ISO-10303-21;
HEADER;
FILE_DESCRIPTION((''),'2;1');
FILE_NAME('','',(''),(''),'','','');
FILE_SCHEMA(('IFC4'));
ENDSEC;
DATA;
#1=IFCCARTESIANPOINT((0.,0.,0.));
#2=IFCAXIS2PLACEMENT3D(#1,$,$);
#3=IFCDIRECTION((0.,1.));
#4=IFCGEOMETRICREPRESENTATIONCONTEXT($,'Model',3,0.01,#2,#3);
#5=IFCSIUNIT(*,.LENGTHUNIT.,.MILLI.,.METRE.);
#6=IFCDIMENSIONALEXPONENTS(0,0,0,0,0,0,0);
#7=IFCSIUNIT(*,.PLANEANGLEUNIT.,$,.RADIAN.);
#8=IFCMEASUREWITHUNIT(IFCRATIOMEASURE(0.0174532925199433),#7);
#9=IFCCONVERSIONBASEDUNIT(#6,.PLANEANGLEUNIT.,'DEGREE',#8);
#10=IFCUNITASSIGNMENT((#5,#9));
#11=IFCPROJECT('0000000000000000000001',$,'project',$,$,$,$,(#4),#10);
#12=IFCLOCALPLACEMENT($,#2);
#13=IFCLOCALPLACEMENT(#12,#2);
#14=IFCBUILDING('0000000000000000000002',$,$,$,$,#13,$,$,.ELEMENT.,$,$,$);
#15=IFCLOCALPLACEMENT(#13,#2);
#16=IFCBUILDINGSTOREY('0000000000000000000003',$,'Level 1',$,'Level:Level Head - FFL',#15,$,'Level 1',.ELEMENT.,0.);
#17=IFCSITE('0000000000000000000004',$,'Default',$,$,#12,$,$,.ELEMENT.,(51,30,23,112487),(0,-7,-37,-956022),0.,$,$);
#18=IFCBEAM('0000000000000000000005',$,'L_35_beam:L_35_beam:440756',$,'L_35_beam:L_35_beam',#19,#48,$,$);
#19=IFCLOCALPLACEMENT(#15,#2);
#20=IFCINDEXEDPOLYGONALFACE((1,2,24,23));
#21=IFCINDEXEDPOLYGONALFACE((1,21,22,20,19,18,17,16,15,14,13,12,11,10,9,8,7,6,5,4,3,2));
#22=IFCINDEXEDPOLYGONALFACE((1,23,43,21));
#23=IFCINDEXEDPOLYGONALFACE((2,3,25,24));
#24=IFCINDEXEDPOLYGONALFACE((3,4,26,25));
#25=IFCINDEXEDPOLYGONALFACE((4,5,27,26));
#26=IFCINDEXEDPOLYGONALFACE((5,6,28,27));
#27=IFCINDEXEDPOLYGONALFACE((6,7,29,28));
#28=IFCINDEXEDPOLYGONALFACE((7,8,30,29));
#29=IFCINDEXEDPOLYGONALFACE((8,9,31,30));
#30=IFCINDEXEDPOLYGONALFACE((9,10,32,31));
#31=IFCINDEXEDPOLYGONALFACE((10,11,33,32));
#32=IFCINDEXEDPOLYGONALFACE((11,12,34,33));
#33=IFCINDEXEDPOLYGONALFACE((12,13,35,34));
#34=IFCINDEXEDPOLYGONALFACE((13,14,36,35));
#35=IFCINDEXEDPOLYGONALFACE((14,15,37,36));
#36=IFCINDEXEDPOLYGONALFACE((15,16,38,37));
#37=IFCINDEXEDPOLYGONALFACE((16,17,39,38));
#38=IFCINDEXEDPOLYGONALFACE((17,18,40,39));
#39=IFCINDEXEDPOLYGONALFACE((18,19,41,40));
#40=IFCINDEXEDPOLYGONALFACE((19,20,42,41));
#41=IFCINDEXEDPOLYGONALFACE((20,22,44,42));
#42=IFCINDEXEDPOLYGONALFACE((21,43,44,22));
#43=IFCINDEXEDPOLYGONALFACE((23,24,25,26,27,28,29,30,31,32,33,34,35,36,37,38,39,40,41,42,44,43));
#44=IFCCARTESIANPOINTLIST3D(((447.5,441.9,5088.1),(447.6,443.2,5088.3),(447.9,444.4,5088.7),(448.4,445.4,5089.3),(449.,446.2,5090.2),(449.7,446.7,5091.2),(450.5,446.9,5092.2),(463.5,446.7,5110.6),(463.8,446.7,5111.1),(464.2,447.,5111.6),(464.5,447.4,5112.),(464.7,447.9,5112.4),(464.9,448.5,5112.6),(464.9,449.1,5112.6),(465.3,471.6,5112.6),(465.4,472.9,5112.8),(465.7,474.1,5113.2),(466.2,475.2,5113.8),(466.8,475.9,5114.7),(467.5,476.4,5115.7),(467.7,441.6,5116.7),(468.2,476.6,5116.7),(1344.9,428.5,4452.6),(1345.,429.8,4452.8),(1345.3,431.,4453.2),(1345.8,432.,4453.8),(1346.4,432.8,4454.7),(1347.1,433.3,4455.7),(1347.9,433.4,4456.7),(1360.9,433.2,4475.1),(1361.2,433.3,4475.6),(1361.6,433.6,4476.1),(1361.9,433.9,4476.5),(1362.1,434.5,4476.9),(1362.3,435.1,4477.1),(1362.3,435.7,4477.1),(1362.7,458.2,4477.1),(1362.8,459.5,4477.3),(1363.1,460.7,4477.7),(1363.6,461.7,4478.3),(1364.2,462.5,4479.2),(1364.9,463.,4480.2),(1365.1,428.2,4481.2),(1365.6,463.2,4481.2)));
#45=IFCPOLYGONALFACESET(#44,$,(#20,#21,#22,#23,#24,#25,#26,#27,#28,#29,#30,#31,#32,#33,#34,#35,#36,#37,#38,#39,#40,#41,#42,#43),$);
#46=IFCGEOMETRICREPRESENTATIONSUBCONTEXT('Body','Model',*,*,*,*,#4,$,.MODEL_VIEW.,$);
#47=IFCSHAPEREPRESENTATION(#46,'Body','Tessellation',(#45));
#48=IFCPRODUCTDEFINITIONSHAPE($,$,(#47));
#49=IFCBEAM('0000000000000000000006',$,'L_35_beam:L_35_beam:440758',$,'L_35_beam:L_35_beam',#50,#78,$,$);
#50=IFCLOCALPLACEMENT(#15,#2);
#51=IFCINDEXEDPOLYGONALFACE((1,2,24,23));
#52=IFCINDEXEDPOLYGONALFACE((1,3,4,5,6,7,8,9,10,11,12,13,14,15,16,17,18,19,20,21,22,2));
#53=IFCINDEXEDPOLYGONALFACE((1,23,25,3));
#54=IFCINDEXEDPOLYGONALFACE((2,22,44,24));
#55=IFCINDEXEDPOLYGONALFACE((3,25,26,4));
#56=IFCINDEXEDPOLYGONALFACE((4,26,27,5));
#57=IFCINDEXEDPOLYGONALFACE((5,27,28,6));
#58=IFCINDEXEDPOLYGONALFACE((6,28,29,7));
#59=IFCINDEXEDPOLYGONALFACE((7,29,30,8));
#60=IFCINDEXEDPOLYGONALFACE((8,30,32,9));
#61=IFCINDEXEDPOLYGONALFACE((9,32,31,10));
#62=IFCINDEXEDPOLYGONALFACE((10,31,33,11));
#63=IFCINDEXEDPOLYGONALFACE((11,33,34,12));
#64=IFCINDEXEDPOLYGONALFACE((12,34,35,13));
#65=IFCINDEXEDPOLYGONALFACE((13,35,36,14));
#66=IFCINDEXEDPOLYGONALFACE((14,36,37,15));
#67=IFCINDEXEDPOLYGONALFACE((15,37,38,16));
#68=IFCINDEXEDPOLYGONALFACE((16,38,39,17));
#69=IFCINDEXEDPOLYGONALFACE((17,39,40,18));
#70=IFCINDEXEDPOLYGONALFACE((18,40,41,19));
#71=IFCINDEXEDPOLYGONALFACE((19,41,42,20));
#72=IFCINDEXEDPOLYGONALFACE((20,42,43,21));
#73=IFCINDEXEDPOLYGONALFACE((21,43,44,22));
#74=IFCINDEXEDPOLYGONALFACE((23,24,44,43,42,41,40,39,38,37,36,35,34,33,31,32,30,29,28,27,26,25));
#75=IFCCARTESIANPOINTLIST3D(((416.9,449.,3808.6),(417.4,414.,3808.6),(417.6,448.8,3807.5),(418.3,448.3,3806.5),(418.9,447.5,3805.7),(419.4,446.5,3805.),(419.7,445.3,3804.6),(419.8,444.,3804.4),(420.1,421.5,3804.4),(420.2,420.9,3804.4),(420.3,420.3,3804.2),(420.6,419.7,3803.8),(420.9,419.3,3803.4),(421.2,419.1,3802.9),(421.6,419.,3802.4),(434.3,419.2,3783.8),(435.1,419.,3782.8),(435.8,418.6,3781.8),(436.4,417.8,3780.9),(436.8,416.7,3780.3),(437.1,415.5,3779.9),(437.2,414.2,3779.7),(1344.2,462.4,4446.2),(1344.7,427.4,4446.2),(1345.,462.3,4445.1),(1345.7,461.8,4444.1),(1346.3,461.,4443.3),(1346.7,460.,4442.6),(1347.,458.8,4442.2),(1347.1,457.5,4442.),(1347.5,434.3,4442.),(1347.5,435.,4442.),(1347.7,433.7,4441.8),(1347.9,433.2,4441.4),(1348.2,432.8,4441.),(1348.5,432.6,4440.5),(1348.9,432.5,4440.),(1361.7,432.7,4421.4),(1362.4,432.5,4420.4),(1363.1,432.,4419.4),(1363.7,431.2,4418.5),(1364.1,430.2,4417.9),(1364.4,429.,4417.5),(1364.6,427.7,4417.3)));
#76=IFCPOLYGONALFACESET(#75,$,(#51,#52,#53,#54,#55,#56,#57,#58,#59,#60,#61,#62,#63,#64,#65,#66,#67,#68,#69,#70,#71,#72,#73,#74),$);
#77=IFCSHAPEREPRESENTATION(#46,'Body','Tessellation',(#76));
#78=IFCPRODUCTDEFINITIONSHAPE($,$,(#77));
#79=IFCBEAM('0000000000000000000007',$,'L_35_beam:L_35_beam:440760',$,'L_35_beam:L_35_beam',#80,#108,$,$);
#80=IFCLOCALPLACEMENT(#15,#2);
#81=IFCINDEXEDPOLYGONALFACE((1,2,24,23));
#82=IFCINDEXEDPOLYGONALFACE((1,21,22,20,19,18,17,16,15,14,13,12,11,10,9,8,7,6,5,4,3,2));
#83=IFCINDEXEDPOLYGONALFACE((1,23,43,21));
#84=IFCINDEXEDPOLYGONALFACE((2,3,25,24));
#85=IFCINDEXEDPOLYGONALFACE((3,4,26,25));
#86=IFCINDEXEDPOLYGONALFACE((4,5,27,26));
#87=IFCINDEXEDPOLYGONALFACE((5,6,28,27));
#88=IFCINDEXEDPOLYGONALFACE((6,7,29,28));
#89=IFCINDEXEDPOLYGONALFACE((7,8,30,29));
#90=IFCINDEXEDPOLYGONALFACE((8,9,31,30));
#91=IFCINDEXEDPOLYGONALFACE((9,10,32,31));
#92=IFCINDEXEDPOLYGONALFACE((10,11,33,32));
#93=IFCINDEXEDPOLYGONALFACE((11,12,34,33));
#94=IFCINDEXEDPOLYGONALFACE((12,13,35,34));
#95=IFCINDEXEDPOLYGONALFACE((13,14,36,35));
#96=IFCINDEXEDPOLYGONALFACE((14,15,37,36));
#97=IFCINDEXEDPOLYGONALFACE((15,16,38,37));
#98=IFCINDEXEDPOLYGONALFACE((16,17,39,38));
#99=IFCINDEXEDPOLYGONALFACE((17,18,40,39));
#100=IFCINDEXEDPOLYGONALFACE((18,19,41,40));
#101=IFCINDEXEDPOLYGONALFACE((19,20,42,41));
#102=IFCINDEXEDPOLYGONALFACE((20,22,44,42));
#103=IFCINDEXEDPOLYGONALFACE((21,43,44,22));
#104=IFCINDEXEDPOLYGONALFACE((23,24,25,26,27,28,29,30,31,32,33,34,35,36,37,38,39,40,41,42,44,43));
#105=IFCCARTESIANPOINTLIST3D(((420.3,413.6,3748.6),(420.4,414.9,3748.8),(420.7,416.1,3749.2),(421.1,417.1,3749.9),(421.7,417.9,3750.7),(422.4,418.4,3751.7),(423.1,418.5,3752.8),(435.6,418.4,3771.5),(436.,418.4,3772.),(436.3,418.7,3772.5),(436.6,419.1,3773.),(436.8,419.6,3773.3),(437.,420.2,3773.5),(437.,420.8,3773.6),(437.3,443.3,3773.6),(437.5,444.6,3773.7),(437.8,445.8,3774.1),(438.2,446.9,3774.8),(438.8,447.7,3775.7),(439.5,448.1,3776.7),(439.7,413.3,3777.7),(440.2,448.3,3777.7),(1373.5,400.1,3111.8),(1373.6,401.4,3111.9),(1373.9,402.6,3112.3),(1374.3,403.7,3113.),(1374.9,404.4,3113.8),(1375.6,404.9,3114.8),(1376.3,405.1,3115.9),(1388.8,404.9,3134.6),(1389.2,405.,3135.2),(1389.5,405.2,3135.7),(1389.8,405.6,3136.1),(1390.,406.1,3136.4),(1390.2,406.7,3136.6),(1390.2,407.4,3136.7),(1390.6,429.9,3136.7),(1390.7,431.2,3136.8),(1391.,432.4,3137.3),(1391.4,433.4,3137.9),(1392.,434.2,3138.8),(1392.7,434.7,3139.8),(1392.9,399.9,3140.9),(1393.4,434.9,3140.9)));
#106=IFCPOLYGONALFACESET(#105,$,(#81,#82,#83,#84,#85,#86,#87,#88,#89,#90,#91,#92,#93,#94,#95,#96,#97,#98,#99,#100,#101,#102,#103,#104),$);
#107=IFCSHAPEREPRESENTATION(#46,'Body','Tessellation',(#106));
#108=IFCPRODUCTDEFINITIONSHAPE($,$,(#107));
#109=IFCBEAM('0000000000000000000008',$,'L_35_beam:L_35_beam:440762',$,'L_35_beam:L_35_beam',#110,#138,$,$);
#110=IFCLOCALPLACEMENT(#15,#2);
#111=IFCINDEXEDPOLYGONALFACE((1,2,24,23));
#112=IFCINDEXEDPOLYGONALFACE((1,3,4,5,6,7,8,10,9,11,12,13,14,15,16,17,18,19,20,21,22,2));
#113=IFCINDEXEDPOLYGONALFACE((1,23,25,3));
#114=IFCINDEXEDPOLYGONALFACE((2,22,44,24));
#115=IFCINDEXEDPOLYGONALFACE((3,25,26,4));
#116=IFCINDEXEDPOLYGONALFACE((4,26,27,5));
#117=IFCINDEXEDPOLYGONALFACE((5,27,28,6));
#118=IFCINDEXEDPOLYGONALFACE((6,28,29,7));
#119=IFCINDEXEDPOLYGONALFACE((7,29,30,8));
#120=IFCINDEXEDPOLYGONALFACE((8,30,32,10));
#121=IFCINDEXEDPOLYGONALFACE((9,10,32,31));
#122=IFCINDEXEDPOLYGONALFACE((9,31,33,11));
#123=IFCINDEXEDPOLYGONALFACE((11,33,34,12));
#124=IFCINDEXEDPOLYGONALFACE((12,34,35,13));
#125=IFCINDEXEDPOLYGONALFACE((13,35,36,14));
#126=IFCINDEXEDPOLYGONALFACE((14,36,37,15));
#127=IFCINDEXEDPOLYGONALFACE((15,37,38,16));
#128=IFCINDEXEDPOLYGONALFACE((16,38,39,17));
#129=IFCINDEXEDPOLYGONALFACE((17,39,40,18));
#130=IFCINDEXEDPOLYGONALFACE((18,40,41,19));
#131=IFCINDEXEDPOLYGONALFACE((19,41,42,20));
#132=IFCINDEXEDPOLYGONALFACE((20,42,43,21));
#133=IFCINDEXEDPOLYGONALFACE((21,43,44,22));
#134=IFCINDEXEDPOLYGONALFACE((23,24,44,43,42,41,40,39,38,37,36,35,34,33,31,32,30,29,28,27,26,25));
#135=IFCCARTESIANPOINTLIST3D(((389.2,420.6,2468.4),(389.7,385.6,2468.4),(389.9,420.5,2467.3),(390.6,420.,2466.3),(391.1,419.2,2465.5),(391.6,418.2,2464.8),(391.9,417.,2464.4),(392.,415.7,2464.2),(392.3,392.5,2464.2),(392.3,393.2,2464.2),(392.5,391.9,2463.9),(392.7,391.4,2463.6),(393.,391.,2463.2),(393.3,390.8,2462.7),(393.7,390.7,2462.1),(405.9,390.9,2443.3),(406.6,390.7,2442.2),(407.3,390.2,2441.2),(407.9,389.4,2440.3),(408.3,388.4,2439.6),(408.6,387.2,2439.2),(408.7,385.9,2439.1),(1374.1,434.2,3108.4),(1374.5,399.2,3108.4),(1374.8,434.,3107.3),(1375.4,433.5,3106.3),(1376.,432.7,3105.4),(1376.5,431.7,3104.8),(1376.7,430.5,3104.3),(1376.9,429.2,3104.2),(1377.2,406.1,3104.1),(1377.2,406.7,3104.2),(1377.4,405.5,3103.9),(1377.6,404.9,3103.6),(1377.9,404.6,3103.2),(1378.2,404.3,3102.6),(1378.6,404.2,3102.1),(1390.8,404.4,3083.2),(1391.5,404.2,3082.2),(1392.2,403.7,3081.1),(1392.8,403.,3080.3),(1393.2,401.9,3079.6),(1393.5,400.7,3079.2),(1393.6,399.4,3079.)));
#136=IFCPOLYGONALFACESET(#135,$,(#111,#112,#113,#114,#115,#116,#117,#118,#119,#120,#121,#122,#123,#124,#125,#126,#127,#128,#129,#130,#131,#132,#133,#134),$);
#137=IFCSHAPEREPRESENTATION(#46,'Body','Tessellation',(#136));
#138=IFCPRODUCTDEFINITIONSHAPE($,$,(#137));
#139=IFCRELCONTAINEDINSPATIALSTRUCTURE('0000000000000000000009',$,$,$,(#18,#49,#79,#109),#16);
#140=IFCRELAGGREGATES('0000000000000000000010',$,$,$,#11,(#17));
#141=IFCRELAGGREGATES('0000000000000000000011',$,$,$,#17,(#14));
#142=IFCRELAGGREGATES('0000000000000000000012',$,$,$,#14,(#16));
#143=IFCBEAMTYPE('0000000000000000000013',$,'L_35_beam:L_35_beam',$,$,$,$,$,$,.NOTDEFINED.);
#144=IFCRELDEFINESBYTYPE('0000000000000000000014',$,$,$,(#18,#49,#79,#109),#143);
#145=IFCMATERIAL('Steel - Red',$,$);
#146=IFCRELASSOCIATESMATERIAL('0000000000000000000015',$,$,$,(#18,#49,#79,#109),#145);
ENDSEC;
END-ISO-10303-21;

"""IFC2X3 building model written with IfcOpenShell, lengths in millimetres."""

from ifc_helpers import new_model, entity, si_unit, converted_unit, direction, frame, frame_2d, origin, place, context, subcontext, project, spatial, polyline, circle_curve, parameter, trimmed, segment, composite_curve, outline, extrude, material, type_object, element, save


model = new_model("IFC2X3")

# Units and contexts
model_context = context("Model", 3, precision=0.01, world=origin(), true_north=direction((0.0, 1.0)))
body_context = subcontext(model_context, "Body", "Model", "MODEL_VIEW")
ifc_project = project(units=[si_unit("LENGTHUNIT", "METRE", prefix="MILLI"), converted_unit("PLANEANGLEUNIT", "DEGREE", entity("IfcRatioMeasure", 0.0174532925199433), si_unit("PLANEANGLEUNIT", "RADIAN"), dimensions=[0, 0, 0, 0, 0, 0, 0])], contexts=[model_context])

# Site, building, storey
site_placement = place(None, origin())
site = spatial("IfcSite", under=ifc_project, at=site_placement, Name="Default", CompositionType="ELEMENT", RefLatitude=(51, 30, 23, 112487), RefLongitude=(0, -7, -37, -956022), RefElevation=0.0)
building_placement = place(site_placement, origin())
building = spatial("IfcBuilding", under=site, at=building_placement, CompositionType="ELEMENT")
storey_placement = place(building_placement, origin())
storey = spatial("IfcBuildingStorey", under=building, at=storey_placement, Name="Level 1", ObjectType="Level:Level Head - FFL", LongName="Level 1", CompositionType="ELEMENT", Elevation=0.0)

# Beams
ifc_material_1 = material(Name="Steel - Red")
beam_type = type_object("IfcBeamType", Name="L_35_beam:L_35_beam", PredefinedType="NOTDEFINED")
beam_1_placement = place(storey_placement, frame((1380.0, 419.9, 4449.1), z_axis=(0.577808, -0.008646, 0.816127), x_axis=(-0.816035, 0.01221, 0.577873)))
element("IfcBeam", 1, at=beam_1_placement, inside=storey, type_object=beam_type, material=ifc_material_1, Name="L_35_beam:L_35_beam:440756", ObjectType="L_35_beam:L_35_beam", context=body_context, shape_type="SweptSolid", body=[
    extrude(outline(composite_curve([segment(polyline([(-23.2, -11.8), (11.8, -11.8)]), True, "CONTINUOUS"), segment(polyline([(11.8, -11.8), (11.8, 23.2)]), True, "CONTINUOUS"), segment(trimmed(circle_curve(frame_2d((11.8, 18.2), x_axis=(0.0, 1.0)), 5.0), [parameter(0.0)], [parameter(90.0)], True, "PARAMETER"), True, "CONTINUOUS"), segment(polyline([(6.8, 18.2), (6.8, -4.3)]), True, "CONTINUOUS"), segment(trimmed(circle_curve(frame_2d((4.3, -4.3), x_axis=(1.0, 0.0)), 2.5), [parameter(270.0)], [parameter(0.0)], True, "PARAMETER"), False, "CONTINUOUS"), segment(polyline([(4.3, -6.8), (-18.2, -6.8)]), True, "CONTINUOUS"), segment(trimmed(circle_curve(frame_2d((-18.2, -11.8), x_axis=(0.0, 1.0)), 5.0), [parameter(0.0)], [parameter(90.0)], True, "PARAMETER"), True, "CONTINUOUS")], self_intersect=False)), frame((30.8, -19.8, 5.7), z_axis=(1.0, 0.0, 0.0), x_axis=(0.0, 0.0, 1.0)), (0.0, 0.0, 1.0), 1099.7),
])
beam_2_placement = place(storey_placement, frame((1380.0, 419.9, 4449.1), z_axis=(-0.566466, -0.00823, 0.824044), x_axis=(-0.823957, -0.01197, -0.566525)))
element("IfcBeam", 2, at=beam_2_placement, inside=storey, type_object=beam_type, material=ifc_material_1, Name="L_35_beam:L_35_beam:440758", ObjectType="L_35_beam:L_35_beam", context=body_context, shape_type="SweptSolid", body=[
    extrude(outline(composite_curve([segment(polyline([(-23.2, -11.8), (11.8, -11.8)]), True, "CONTINUOUS"), segment(polyline([(11.8, -11.8), (11.8, 23.2)]), True, "CONTINUOUS"), segment(trimmed(circle_curve(frame_2d((11.8, 18.2), x_axis=(0.0, 1.0)), 5.0), [parameter(0.0)], [parameter(90.0)], True, "PARAMETER"), True, "CONTINUOUS"), segment(polyline([(6.8, 18.2), (6.8, -4.3)]), True, "CONTINUOUS"), segment(trimmed(circle_curve(frame_2d((4.3, -4.3), x_axis=(1.0, 0.0)), 2.5), [parameter(270.0)], [parameter(0.0)], True, "PARAMETER"), False, "CONTINUOUS"), segment(polyline([(4.3, -6.8), (-18.2, -6.8)]), True, "CONTINUOUS"), segment(trimmed(circle_curve(frame_2d((-18.2, -11.8), x_axis=(0.0, 1.0)), 5.0), [parameter(0.0)], [parameter(90.0)], True, "PARAMETER"), True, "CONTINUOUS")], self_intersect=False)), frame((30.7, -19.8, 5.7), z_axis=(1.0, 0.0, 0.0), x_axis=(0.0, 0.0, 1.0)), (0.0, 0.0, 1.0), 1125.5),
])
beam_3_placement = place(storey_placement, frame((1408.4, 391.6, 3109.4), z_axis=(0.555459, -0.007842, 0.831507), x_axis=(-0.831424, 0.011738, 0.555515)))
element("IfcBeam", 3, at=beam_3_placement, inside=storey, type_object=beam_type, material=ifc_material_1, Name="L_35_beam:L_35_beam:440760", ObjectType="L_35_beam:L_35_beam", context=body_context, shape_type="SweptSolid", body=[
    extrude(outline(composite_curve([segment(polyline([(-23.2, -11.8), (11.8, -11.8)]), True, "CONTINUOUS"), segment(polyline([(11.8, -11.8), (11.8, 23.2)]), True, "CONTINUOUS"), segment(trimmed(circle_curve(frame_2d((11.8, 18.2), x_axis=(0.0, 1.0)), 5.0), [parameter(0.0)], [parameter(90.0)], True, "PARAMETER"), True, "CONTINUOUS"), segment(polyline([(6.8, 18.2), (6.8, -4.3)]), True, "CONTINUOUS"), segment(trimmed(circle_curve(frame_2d((4.3, -4.3), x_axis=(1.0, 0.0)), 2.5), [parameter(270.0)], [parameter(0.0)], True, "PARAMETER"), False, "CONTINUOUS"), segment(polyline([(4.3, -6.8), (-18.2, -6.8)]), True, "CONTINUOUS"), segment(trimmed(circle_curve(frame_2d((-18.2, -11.8), x_axis=(0.0, 1.0)), 5.0), [parameter(0.0)], [parameter(90.0)], True, "PARAMETER"), True, "CONTINUOUS")], self_intersect=False)), frame((30.4, -19.8, 5.7), z_axis=(1.0, 0.0, 0.0), x_axis=(0.0, 0.0, 1.0)), (0.0, 0.0, 1.0), 1146.5),
])
beam_4_placement = place(storey_placement, frame((1408.4, 391.6, 3109.4), z_axis=(-0.544781, -0.00748, 0.838545), x_axis=(-0.838466, -0.011512, -0.544833)))
element("IfcBeam", 4, at=beam_4_placement, inside=storey, type_object=beam_type, material=ifc_material_1, Name="L_35_beam:L_35_beam:440762", ObjectType="L_35_beam:L_35_beam", context=body_context, shape_type="SweptSolid", body=[
    extrude(outline(composite_curve([segment(polyline([(-23.2, -11.8), (11.8, -11.8)]), True, "CONTINUOUS"), segment(polyline([(11.8, -11.8), (11.8, 23.2)]), True, "CONTINUOUS"), segment(trimmed(circle_curve(frame_2d((11.8, 18.2), x_axis=(0.0, 1.0)), 5.0), [parameter(0.0)], [parameter(90.0)], True, "PARAMETER"), True, "CONTINUOUS"), segment(polyline([(6.8, 18.2), (6.8, -4.3)]), True, "CONTINUOUS"), segment(trimmed(circle_curve(frame_2d((4.3, -4.3), x_axis=(1.0, 0.0)), 2.5), [parameter(270.0)], [parameter(0.0)], True, "PARAMETER"), False, "CONTINUOUS"), segment(polyline([(4.3, -6.8), (-18.2, -6.8)]), True, "CONTINUOUS"), segment(trimmed(circle_curve(frame_2d((-18.2, -11.8), x_axis=(0.0, 1.0)), 5.0), [parameter(0.0)], [parameter(90.0)], True, "PARAMETER"), True, "CONTINUOUS")], self_intersect=False)), frame((28.8, -19.8, 5.7), z_axis=(1.0, 0.0, 0.0), x_axis=(0.0, 0.0, 1.0)), (0.0, 0.0, 1.0), 1174.6),
])

save(model, "model.ifc")
